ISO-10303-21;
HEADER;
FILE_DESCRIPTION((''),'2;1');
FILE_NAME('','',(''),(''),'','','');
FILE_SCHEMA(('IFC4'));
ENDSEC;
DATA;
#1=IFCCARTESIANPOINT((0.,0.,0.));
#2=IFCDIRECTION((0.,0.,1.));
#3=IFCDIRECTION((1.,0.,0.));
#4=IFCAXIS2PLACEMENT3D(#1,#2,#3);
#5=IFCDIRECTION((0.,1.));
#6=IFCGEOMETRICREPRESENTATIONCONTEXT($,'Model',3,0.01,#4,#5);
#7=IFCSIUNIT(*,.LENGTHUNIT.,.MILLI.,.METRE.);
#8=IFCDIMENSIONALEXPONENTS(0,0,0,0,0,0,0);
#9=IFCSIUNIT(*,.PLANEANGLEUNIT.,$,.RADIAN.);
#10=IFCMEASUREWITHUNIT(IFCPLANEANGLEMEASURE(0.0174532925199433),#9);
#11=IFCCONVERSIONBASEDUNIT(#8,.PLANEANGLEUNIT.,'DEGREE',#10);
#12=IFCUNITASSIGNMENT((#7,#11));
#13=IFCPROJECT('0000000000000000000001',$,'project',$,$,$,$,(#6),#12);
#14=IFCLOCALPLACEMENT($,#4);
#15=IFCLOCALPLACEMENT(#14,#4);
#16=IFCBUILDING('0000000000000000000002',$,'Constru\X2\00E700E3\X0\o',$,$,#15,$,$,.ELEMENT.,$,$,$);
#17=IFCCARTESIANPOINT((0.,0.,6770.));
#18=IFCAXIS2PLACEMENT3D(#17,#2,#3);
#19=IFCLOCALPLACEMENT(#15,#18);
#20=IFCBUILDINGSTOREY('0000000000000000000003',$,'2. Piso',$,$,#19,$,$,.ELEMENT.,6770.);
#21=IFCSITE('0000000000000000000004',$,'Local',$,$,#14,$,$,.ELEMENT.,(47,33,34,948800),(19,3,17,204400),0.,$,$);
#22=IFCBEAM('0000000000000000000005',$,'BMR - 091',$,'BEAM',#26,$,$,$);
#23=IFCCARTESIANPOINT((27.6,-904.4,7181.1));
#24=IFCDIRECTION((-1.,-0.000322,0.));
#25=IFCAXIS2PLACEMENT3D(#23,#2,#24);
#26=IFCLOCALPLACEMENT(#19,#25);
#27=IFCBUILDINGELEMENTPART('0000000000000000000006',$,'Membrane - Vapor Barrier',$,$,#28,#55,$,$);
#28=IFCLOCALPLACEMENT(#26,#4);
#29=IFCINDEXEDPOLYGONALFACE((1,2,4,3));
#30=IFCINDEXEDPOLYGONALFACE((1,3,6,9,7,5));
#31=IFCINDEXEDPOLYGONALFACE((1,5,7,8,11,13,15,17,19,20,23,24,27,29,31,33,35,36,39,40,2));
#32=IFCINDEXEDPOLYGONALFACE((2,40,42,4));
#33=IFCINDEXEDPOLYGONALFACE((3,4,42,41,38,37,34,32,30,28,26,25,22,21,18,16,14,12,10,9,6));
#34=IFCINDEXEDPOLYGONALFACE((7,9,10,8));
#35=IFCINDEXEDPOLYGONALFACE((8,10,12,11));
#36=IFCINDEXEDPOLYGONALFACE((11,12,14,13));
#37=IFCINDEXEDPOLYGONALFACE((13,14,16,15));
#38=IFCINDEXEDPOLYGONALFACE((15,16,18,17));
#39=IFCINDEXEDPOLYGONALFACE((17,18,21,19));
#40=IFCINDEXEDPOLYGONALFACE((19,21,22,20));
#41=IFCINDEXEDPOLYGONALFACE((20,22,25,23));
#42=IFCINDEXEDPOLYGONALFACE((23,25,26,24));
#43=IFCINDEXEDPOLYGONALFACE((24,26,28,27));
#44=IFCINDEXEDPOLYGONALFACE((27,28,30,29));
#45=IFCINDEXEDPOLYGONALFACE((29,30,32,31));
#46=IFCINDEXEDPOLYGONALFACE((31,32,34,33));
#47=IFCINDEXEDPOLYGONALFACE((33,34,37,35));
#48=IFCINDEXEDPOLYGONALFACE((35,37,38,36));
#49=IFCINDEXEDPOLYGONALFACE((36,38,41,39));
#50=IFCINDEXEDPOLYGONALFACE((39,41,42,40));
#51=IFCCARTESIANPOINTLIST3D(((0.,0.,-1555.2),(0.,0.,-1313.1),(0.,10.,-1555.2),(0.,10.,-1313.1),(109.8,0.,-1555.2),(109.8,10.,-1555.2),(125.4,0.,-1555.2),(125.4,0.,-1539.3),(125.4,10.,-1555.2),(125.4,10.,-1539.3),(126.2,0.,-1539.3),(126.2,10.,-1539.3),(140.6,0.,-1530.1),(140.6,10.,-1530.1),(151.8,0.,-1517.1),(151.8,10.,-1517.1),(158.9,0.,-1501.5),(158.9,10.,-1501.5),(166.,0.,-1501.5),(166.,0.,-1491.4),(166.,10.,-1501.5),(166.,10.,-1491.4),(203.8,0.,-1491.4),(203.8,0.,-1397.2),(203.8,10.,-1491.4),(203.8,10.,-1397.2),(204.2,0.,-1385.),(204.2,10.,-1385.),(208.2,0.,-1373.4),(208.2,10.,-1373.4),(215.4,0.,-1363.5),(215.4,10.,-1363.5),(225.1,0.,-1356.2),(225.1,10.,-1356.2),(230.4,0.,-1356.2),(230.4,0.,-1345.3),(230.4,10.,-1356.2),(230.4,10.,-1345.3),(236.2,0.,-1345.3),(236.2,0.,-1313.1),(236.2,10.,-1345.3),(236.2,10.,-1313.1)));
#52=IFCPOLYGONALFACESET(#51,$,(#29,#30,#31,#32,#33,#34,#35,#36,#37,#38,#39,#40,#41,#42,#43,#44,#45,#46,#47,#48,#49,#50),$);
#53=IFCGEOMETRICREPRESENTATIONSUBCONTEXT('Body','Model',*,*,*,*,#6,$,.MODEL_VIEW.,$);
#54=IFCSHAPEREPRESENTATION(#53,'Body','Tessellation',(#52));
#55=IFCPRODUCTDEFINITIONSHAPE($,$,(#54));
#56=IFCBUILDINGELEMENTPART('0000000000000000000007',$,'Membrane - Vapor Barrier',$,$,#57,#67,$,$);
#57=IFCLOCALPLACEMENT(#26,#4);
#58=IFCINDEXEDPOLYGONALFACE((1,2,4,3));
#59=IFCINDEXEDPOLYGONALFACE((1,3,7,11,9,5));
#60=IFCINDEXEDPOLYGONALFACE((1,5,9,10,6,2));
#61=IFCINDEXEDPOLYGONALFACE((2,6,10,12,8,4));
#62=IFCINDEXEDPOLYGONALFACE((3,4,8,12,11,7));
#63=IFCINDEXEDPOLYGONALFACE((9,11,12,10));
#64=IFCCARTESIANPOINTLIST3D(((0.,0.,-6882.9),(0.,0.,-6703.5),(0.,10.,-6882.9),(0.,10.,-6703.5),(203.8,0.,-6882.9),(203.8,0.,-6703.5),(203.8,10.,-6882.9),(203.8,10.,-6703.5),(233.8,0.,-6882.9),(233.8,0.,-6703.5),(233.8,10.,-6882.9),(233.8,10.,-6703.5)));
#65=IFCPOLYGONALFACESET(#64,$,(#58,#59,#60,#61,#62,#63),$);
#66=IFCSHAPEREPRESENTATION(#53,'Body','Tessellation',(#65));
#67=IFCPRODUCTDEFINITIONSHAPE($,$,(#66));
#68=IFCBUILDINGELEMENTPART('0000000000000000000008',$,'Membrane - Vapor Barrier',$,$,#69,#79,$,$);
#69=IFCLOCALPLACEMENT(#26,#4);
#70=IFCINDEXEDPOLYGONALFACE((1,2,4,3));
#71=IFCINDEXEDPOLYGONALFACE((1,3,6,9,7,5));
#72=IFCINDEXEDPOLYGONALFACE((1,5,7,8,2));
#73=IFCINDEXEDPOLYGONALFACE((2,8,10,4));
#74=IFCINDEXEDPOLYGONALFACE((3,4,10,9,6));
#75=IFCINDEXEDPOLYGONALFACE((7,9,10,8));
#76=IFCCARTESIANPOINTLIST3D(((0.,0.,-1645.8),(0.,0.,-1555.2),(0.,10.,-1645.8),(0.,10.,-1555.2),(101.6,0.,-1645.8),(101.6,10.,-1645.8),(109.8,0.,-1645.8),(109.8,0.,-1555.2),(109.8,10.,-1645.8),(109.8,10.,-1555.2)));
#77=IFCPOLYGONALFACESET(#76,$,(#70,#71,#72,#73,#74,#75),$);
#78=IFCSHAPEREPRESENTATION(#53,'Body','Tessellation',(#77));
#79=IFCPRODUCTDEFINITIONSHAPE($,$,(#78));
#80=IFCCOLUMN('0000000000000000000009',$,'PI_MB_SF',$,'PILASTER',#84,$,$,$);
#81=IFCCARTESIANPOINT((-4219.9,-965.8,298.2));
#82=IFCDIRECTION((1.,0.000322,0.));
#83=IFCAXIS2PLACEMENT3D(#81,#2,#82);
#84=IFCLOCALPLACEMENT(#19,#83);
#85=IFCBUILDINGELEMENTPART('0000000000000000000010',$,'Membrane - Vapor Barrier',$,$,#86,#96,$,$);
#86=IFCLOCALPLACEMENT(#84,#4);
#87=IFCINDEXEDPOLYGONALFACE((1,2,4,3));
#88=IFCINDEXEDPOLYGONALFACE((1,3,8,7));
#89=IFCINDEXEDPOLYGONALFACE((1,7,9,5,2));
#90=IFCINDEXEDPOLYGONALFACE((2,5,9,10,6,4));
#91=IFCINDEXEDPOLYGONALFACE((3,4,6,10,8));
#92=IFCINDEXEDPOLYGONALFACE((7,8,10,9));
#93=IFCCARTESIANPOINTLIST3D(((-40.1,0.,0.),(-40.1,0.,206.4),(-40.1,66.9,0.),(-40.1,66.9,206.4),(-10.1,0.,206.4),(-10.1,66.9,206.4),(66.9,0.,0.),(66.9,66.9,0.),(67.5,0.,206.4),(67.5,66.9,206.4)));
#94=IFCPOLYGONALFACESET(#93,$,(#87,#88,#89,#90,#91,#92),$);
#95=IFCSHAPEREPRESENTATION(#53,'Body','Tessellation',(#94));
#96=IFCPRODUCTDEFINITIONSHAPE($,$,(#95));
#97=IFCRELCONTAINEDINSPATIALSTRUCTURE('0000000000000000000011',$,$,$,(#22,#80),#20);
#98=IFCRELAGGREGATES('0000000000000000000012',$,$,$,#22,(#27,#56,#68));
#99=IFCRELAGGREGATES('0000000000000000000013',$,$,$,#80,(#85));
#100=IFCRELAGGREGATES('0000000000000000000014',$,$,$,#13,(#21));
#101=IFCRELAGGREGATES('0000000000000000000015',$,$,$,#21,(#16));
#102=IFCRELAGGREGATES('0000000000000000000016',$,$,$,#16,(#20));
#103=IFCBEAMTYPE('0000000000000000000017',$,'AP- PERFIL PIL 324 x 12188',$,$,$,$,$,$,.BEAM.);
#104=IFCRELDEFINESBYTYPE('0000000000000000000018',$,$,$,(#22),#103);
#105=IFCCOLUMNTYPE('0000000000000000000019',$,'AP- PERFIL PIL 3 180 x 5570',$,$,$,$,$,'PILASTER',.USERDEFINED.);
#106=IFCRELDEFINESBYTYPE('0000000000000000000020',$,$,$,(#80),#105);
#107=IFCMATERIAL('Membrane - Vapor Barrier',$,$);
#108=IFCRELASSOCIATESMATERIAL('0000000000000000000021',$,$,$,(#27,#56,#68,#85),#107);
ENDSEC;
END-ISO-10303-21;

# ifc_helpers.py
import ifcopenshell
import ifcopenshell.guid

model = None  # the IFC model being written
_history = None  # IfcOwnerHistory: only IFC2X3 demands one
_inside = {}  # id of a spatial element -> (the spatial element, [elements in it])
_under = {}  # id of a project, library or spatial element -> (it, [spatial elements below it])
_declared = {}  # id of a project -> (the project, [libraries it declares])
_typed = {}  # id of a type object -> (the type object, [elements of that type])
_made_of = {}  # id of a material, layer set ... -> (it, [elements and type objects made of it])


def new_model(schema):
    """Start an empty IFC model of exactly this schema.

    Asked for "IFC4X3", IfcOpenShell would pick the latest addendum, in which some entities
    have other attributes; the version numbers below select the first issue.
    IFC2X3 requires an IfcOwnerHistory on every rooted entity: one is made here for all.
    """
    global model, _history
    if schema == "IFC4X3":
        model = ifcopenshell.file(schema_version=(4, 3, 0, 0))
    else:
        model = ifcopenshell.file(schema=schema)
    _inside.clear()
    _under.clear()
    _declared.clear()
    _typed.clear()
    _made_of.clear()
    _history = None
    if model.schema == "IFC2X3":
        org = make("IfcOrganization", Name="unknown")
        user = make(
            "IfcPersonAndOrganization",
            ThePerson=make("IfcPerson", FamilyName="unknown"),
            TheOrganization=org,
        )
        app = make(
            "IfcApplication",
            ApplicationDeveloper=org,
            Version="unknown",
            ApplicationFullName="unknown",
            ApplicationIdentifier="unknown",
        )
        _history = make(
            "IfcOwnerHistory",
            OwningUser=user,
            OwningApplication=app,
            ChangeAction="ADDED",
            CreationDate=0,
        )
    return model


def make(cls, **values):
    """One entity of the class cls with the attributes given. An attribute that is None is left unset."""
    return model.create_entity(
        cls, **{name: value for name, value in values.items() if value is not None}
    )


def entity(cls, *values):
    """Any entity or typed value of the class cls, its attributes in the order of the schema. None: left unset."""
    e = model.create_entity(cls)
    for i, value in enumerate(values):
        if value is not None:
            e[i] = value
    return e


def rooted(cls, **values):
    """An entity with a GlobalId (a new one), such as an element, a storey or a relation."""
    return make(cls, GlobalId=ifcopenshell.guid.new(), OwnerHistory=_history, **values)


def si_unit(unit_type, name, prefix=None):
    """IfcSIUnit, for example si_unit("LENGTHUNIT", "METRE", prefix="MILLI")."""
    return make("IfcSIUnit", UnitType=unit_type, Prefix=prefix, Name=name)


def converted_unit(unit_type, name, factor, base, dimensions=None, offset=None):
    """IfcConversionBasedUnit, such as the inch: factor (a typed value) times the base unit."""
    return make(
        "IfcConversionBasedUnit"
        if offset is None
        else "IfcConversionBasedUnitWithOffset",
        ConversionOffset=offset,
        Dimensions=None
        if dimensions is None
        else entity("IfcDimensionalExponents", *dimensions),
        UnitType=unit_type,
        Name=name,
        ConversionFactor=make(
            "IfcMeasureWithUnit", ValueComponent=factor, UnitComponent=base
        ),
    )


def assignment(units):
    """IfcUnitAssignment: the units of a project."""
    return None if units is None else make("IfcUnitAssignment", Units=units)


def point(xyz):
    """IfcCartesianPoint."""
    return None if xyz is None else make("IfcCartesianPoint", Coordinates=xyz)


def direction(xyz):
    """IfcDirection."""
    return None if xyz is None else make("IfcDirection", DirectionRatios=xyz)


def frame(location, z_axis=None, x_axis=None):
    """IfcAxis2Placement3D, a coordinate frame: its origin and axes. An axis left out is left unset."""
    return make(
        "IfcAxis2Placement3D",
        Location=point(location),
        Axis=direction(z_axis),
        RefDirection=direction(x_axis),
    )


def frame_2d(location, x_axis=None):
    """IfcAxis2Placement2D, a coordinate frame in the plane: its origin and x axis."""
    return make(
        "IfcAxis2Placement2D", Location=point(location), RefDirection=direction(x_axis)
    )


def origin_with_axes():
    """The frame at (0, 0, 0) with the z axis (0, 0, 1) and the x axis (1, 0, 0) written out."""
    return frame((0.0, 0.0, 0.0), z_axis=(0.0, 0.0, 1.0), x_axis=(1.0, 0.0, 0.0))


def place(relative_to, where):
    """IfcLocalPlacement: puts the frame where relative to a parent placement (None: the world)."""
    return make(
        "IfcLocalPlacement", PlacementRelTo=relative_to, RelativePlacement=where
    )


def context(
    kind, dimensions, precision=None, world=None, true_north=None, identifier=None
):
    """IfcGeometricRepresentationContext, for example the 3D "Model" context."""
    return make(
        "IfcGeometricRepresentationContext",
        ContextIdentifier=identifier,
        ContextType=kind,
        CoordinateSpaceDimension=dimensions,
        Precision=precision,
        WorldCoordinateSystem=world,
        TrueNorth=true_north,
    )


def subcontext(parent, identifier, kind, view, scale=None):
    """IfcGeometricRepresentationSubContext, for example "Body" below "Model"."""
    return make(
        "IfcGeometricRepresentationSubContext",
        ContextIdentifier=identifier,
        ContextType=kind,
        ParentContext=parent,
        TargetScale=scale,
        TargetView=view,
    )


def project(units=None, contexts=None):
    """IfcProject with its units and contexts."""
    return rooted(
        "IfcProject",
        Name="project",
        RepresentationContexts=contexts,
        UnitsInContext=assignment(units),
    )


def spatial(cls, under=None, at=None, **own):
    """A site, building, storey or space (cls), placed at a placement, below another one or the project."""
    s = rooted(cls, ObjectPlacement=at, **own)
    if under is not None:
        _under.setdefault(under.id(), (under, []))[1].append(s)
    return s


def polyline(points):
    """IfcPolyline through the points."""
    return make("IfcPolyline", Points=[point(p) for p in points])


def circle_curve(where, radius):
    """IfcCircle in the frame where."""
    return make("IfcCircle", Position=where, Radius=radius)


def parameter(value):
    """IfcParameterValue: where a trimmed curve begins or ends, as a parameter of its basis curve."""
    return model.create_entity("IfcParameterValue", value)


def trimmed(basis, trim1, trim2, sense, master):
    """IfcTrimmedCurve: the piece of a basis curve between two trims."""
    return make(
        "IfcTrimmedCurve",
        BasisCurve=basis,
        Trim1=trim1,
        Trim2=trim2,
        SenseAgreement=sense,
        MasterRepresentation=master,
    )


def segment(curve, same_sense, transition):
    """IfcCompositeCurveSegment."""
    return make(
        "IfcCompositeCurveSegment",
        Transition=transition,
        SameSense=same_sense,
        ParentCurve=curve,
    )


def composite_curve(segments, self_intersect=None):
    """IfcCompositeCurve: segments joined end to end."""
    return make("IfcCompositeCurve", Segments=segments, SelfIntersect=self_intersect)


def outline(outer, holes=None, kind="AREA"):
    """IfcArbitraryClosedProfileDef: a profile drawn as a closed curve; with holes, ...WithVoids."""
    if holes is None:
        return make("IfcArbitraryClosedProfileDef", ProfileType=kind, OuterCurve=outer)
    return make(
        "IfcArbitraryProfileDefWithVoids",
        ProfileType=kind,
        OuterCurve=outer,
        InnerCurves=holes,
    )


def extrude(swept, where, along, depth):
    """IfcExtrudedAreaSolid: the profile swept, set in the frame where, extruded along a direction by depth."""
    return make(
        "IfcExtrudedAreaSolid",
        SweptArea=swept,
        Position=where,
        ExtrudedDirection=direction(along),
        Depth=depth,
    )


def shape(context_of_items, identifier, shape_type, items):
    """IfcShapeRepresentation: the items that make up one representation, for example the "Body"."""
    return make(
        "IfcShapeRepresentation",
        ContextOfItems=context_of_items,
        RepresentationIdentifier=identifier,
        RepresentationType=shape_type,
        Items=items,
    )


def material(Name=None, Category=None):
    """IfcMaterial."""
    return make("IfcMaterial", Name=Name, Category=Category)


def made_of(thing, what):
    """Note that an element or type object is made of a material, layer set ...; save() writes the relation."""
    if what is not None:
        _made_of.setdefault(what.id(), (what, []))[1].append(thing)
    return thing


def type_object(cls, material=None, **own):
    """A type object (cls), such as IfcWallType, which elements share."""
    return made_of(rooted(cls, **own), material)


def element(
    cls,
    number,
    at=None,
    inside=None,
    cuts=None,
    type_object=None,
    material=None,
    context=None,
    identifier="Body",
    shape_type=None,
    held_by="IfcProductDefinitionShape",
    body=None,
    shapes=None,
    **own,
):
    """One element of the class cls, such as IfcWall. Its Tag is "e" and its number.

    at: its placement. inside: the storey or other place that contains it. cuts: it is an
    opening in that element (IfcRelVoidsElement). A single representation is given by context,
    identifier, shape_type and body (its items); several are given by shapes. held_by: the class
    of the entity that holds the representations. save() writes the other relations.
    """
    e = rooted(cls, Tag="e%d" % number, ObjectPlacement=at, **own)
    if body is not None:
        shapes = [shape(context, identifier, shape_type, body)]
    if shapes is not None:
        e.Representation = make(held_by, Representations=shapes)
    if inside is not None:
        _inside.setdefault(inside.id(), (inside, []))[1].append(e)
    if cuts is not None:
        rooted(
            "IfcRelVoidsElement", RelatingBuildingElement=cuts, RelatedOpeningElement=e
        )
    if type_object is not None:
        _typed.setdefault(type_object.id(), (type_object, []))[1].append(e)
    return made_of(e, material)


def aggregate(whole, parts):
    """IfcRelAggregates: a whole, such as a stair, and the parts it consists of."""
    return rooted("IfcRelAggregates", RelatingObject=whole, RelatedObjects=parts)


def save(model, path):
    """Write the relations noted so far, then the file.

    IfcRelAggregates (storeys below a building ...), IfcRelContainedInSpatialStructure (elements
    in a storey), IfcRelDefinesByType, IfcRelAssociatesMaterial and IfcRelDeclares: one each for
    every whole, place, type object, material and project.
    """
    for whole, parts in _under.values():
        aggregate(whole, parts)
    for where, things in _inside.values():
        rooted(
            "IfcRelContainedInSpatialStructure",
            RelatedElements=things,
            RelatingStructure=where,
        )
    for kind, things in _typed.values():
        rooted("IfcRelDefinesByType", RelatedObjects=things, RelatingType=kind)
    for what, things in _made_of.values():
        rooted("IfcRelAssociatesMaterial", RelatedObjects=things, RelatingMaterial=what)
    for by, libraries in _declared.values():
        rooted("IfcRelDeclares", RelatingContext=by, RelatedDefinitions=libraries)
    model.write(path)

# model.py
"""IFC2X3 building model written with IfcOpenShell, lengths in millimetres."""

from ifc_helpers import new_model, entity, si_unit, converted_unit, point, direction, frame, frame_2d, origin_with_axes, place, context, subcontext, project, spatial, polyline, circle_curve, parameter, trimmed, segment, composite_curve, outline, extrude, material, type_object, element, aggregate, save


model = new_model("IFC2X3")

# Units and contexts
model_context = context("Model", 3, precision=0.01, world=origin_with_axes(), true_north=direction((0.0, 1.0)))
body_context = subcontext(model_context, "Body", "Model", "MODEL_VIEW")
ifc_project = project(units=[si_unit("LENGTHUNIT", "METRE", prefix="MILLI"), converted_unit("PLANEANGLEUNIT", "DEGREE", entity("IfcPlaneAngleMeasure", 0.0174532925199433), si_unit("PLANEANGLEUNIT", "RADIAN"), dimensions=[0, 0, 0, 0, 0, 0, 0])], contexts=[model_context])

# Site, building, storey
site_placement = place(None, origin_with_axes())
site = spatial("IfcSite", under=ifc_project, at=site_placement, Name="Local", CompositionType="ELEMENT", RefLatitude=(47, 33, 34, 948800), RefLongitude=(19, 3, 17, 204400), RefElevation=0.0)
building_placement = place(site_placement, origin_with_axes())
building = spatial("IfcBuilding", under=site, at=building_placement, Name="Construção", CompositionType="ELEMENT")
storey_placement = place(building_placement, frame((0.0, 0.0, 6770.0), z_axis=(0.0, 0.0, 1.0), x_axis=(1.0, 0.0, 0.0)))
storey = spatial("IfcBuildingStorey", under=building, at=storey_placement, Name="2. Piso", CompositionType="ELEMENT", Elevation=6770.0)

# Shared definitions
column_type = type_object("IfcColumnType", Name="AP- PERFIL PIL 3 180 x 5570", ElementType="PILASTER", PredefinedType="USERDEFINED")
ifc_material = material(Name="Membrane - Vapor Barrier")

# Beam, building element parts
beam_type = type_object("IfcBeamType", Name="AP- PERFIL PIL 324 x 12188", PredefinedType="BEAM")
beam_placement = place(storey_placement, frame((27.6, -904.4, 7181.1), z_axis=(0.0, 0.0, 1.0), x_axis=(-1.0, -0.000322, 0.0)))
beam = element("IfcBeam", 1, at=beam_placement, inside=storey, type_object=beam_type, Name="BMR - 091", ObjectType="BEAM")
building_element_part_1_placement = place(beam_placement, origin_with_axes())
building_element_part_1 = element("IfcBuildingElementPart", 2, at=building_element_part_1_placement, material=ifc_material, Name="Membrane - Vapor Barrier", context=body_context, shape_type="SweptSolid", body=[
    extrude(outline(composite_curve([segment(polyline([(0.0, -1555.2), (109.8, -1555.2), (125.4, -1555.2), (125.4, -1539.3), (126.2, -1539.3)]), True, "CONTINUOUS"), segment(trimmed(circle_curve(frame_2d((101.8, -1485.2), x_axis=(0.411627, -0.911352)), 59.4), [point((126.2, -1539.3)), parameter(0.0)], [point((158.9, -1501.5)), parameter(49.79606)], True, "CARTESIAN"), True, "CONTINUOUS"), segment(polyline([(158.9, -1501.5), (166.0, -1501.5), (166.0, -1491.4), (203.8, -1491.4), (203.8, -1397.2)]), True, "CONTINUOUS"), segment(trimmed(circle_curve(frame_2d((245.0, -1392.6), x_axis=(-0.480333, 0.877086)), 41.5), [point((203.8, -1397.2)), parameter(67.594129)], [point((225.1, -1356.2)), parameter(0.0)], False, "CARTESIAN"), True, "CONTINUOUS"), segment(polyline([(225.1, -1356.2), (230.4, -1356.2), (230.4, -1345.3), (236.2, -1345.3), (236.2, -1313.1), (0.0, -1313.1), (0.0, -1555.2)]), True, "CONTINUOUS")], self_intersect=False)), frame((0.0, 10.0, 0.0), z_axis=(0.0, -1.0, 0.0), x_axis=(1.0, 0.0, 0.0)), (0.0, 0.0, 1.0), 10.0),
])
building_element_part_2_placement = place(beam_placement, origin_with_axes())
building_element_part_2 = element("IfcBuildingElementPart", 3, at=building_element_part_2_placement, material=ifc_material, Name="Membrane - Vapor Barrier", context=body_context, shape_type="SweptSolid", body=[
    extrude(outline(polyline([(233.8, -6882.9), (233.8, -6703.5), (203.8, -6703.5), (0.0, -6703.5), (0.0, -6882.9), (203.8, -6882.9), (233.8, -6882.9)])), frame((0.0, 10.0, 0.0), z_axis=(0.0, -1.0, 0.0), x_axis=(1.0, 0.0, 0.0)), (0.0, 0.0, 1.0), 10.0),
])
building_element_part_3_placement = place(beam_placement, origin_with_axes())
building_element_part_3 = element("IfcBuildingElementPart", 4, at=building_element_part_3_placement, material=ifc_material, Name="Membrane - Vapor Barrier", context=body_context, shape_type="SweptSolid", body=[
    extrude(outline(polyline([(0.0, -1645.8), (101.6, -1645.8), (109.8, -1645.8), (109.8, -1555.2), (0.0, -1555.2), (0.0, -1645.8)])), frame((0.0, 10.0, 0.0), z_axis=(0.0, -1.0, 0.0), x_axis=(1.0, 0.0, 0.0)), (0.0, 0.0, 1.0), 10.0),
])
aggregate(beam, [building_element_part_1, building_element_part_2, building_element_part_3])

# Column, building element part
column_1_placement = place(storey_placement, frame((-4219.9, -965.8, 298.2), z_axis=(0.0, 0.0, 1.0), x_axis=(1.0, 0.000322, 0.0)))
column_1 = element("IfcColumn", 5, at=column_1_placement, inside=storey, type_object=column_type, Name="PI_MB_SF", ObjectType="PILASTER")
building_element_part_4_placement = place(column_1_placement, origin_with_axes())
building_element_part_4 = element("IfcBuildingElementPart", 6, at=building_element_part_4_placement, material=ifc_material, Name="Membrane - Vapor Barrier", context=body_context, shape_type="SweptSolid", body=[
    extrude(outline(polyline([(40.1, 0.0), (40.1, 206.4), (10.1, 206.4), (-67.5, 206.4), (-66.9, 0.0), (40.1, 0.0)])), frame((0.0, 66.9, 0.0), z_axis=(0.0, 1.0, 0.0), x_axis=(-1.0, 0.0, 0.0)), (0.0, 0.0, -1.0), 66.9),
])
aggregate(column_1, [building_element_part_4])

save(model, "model.ifc")
